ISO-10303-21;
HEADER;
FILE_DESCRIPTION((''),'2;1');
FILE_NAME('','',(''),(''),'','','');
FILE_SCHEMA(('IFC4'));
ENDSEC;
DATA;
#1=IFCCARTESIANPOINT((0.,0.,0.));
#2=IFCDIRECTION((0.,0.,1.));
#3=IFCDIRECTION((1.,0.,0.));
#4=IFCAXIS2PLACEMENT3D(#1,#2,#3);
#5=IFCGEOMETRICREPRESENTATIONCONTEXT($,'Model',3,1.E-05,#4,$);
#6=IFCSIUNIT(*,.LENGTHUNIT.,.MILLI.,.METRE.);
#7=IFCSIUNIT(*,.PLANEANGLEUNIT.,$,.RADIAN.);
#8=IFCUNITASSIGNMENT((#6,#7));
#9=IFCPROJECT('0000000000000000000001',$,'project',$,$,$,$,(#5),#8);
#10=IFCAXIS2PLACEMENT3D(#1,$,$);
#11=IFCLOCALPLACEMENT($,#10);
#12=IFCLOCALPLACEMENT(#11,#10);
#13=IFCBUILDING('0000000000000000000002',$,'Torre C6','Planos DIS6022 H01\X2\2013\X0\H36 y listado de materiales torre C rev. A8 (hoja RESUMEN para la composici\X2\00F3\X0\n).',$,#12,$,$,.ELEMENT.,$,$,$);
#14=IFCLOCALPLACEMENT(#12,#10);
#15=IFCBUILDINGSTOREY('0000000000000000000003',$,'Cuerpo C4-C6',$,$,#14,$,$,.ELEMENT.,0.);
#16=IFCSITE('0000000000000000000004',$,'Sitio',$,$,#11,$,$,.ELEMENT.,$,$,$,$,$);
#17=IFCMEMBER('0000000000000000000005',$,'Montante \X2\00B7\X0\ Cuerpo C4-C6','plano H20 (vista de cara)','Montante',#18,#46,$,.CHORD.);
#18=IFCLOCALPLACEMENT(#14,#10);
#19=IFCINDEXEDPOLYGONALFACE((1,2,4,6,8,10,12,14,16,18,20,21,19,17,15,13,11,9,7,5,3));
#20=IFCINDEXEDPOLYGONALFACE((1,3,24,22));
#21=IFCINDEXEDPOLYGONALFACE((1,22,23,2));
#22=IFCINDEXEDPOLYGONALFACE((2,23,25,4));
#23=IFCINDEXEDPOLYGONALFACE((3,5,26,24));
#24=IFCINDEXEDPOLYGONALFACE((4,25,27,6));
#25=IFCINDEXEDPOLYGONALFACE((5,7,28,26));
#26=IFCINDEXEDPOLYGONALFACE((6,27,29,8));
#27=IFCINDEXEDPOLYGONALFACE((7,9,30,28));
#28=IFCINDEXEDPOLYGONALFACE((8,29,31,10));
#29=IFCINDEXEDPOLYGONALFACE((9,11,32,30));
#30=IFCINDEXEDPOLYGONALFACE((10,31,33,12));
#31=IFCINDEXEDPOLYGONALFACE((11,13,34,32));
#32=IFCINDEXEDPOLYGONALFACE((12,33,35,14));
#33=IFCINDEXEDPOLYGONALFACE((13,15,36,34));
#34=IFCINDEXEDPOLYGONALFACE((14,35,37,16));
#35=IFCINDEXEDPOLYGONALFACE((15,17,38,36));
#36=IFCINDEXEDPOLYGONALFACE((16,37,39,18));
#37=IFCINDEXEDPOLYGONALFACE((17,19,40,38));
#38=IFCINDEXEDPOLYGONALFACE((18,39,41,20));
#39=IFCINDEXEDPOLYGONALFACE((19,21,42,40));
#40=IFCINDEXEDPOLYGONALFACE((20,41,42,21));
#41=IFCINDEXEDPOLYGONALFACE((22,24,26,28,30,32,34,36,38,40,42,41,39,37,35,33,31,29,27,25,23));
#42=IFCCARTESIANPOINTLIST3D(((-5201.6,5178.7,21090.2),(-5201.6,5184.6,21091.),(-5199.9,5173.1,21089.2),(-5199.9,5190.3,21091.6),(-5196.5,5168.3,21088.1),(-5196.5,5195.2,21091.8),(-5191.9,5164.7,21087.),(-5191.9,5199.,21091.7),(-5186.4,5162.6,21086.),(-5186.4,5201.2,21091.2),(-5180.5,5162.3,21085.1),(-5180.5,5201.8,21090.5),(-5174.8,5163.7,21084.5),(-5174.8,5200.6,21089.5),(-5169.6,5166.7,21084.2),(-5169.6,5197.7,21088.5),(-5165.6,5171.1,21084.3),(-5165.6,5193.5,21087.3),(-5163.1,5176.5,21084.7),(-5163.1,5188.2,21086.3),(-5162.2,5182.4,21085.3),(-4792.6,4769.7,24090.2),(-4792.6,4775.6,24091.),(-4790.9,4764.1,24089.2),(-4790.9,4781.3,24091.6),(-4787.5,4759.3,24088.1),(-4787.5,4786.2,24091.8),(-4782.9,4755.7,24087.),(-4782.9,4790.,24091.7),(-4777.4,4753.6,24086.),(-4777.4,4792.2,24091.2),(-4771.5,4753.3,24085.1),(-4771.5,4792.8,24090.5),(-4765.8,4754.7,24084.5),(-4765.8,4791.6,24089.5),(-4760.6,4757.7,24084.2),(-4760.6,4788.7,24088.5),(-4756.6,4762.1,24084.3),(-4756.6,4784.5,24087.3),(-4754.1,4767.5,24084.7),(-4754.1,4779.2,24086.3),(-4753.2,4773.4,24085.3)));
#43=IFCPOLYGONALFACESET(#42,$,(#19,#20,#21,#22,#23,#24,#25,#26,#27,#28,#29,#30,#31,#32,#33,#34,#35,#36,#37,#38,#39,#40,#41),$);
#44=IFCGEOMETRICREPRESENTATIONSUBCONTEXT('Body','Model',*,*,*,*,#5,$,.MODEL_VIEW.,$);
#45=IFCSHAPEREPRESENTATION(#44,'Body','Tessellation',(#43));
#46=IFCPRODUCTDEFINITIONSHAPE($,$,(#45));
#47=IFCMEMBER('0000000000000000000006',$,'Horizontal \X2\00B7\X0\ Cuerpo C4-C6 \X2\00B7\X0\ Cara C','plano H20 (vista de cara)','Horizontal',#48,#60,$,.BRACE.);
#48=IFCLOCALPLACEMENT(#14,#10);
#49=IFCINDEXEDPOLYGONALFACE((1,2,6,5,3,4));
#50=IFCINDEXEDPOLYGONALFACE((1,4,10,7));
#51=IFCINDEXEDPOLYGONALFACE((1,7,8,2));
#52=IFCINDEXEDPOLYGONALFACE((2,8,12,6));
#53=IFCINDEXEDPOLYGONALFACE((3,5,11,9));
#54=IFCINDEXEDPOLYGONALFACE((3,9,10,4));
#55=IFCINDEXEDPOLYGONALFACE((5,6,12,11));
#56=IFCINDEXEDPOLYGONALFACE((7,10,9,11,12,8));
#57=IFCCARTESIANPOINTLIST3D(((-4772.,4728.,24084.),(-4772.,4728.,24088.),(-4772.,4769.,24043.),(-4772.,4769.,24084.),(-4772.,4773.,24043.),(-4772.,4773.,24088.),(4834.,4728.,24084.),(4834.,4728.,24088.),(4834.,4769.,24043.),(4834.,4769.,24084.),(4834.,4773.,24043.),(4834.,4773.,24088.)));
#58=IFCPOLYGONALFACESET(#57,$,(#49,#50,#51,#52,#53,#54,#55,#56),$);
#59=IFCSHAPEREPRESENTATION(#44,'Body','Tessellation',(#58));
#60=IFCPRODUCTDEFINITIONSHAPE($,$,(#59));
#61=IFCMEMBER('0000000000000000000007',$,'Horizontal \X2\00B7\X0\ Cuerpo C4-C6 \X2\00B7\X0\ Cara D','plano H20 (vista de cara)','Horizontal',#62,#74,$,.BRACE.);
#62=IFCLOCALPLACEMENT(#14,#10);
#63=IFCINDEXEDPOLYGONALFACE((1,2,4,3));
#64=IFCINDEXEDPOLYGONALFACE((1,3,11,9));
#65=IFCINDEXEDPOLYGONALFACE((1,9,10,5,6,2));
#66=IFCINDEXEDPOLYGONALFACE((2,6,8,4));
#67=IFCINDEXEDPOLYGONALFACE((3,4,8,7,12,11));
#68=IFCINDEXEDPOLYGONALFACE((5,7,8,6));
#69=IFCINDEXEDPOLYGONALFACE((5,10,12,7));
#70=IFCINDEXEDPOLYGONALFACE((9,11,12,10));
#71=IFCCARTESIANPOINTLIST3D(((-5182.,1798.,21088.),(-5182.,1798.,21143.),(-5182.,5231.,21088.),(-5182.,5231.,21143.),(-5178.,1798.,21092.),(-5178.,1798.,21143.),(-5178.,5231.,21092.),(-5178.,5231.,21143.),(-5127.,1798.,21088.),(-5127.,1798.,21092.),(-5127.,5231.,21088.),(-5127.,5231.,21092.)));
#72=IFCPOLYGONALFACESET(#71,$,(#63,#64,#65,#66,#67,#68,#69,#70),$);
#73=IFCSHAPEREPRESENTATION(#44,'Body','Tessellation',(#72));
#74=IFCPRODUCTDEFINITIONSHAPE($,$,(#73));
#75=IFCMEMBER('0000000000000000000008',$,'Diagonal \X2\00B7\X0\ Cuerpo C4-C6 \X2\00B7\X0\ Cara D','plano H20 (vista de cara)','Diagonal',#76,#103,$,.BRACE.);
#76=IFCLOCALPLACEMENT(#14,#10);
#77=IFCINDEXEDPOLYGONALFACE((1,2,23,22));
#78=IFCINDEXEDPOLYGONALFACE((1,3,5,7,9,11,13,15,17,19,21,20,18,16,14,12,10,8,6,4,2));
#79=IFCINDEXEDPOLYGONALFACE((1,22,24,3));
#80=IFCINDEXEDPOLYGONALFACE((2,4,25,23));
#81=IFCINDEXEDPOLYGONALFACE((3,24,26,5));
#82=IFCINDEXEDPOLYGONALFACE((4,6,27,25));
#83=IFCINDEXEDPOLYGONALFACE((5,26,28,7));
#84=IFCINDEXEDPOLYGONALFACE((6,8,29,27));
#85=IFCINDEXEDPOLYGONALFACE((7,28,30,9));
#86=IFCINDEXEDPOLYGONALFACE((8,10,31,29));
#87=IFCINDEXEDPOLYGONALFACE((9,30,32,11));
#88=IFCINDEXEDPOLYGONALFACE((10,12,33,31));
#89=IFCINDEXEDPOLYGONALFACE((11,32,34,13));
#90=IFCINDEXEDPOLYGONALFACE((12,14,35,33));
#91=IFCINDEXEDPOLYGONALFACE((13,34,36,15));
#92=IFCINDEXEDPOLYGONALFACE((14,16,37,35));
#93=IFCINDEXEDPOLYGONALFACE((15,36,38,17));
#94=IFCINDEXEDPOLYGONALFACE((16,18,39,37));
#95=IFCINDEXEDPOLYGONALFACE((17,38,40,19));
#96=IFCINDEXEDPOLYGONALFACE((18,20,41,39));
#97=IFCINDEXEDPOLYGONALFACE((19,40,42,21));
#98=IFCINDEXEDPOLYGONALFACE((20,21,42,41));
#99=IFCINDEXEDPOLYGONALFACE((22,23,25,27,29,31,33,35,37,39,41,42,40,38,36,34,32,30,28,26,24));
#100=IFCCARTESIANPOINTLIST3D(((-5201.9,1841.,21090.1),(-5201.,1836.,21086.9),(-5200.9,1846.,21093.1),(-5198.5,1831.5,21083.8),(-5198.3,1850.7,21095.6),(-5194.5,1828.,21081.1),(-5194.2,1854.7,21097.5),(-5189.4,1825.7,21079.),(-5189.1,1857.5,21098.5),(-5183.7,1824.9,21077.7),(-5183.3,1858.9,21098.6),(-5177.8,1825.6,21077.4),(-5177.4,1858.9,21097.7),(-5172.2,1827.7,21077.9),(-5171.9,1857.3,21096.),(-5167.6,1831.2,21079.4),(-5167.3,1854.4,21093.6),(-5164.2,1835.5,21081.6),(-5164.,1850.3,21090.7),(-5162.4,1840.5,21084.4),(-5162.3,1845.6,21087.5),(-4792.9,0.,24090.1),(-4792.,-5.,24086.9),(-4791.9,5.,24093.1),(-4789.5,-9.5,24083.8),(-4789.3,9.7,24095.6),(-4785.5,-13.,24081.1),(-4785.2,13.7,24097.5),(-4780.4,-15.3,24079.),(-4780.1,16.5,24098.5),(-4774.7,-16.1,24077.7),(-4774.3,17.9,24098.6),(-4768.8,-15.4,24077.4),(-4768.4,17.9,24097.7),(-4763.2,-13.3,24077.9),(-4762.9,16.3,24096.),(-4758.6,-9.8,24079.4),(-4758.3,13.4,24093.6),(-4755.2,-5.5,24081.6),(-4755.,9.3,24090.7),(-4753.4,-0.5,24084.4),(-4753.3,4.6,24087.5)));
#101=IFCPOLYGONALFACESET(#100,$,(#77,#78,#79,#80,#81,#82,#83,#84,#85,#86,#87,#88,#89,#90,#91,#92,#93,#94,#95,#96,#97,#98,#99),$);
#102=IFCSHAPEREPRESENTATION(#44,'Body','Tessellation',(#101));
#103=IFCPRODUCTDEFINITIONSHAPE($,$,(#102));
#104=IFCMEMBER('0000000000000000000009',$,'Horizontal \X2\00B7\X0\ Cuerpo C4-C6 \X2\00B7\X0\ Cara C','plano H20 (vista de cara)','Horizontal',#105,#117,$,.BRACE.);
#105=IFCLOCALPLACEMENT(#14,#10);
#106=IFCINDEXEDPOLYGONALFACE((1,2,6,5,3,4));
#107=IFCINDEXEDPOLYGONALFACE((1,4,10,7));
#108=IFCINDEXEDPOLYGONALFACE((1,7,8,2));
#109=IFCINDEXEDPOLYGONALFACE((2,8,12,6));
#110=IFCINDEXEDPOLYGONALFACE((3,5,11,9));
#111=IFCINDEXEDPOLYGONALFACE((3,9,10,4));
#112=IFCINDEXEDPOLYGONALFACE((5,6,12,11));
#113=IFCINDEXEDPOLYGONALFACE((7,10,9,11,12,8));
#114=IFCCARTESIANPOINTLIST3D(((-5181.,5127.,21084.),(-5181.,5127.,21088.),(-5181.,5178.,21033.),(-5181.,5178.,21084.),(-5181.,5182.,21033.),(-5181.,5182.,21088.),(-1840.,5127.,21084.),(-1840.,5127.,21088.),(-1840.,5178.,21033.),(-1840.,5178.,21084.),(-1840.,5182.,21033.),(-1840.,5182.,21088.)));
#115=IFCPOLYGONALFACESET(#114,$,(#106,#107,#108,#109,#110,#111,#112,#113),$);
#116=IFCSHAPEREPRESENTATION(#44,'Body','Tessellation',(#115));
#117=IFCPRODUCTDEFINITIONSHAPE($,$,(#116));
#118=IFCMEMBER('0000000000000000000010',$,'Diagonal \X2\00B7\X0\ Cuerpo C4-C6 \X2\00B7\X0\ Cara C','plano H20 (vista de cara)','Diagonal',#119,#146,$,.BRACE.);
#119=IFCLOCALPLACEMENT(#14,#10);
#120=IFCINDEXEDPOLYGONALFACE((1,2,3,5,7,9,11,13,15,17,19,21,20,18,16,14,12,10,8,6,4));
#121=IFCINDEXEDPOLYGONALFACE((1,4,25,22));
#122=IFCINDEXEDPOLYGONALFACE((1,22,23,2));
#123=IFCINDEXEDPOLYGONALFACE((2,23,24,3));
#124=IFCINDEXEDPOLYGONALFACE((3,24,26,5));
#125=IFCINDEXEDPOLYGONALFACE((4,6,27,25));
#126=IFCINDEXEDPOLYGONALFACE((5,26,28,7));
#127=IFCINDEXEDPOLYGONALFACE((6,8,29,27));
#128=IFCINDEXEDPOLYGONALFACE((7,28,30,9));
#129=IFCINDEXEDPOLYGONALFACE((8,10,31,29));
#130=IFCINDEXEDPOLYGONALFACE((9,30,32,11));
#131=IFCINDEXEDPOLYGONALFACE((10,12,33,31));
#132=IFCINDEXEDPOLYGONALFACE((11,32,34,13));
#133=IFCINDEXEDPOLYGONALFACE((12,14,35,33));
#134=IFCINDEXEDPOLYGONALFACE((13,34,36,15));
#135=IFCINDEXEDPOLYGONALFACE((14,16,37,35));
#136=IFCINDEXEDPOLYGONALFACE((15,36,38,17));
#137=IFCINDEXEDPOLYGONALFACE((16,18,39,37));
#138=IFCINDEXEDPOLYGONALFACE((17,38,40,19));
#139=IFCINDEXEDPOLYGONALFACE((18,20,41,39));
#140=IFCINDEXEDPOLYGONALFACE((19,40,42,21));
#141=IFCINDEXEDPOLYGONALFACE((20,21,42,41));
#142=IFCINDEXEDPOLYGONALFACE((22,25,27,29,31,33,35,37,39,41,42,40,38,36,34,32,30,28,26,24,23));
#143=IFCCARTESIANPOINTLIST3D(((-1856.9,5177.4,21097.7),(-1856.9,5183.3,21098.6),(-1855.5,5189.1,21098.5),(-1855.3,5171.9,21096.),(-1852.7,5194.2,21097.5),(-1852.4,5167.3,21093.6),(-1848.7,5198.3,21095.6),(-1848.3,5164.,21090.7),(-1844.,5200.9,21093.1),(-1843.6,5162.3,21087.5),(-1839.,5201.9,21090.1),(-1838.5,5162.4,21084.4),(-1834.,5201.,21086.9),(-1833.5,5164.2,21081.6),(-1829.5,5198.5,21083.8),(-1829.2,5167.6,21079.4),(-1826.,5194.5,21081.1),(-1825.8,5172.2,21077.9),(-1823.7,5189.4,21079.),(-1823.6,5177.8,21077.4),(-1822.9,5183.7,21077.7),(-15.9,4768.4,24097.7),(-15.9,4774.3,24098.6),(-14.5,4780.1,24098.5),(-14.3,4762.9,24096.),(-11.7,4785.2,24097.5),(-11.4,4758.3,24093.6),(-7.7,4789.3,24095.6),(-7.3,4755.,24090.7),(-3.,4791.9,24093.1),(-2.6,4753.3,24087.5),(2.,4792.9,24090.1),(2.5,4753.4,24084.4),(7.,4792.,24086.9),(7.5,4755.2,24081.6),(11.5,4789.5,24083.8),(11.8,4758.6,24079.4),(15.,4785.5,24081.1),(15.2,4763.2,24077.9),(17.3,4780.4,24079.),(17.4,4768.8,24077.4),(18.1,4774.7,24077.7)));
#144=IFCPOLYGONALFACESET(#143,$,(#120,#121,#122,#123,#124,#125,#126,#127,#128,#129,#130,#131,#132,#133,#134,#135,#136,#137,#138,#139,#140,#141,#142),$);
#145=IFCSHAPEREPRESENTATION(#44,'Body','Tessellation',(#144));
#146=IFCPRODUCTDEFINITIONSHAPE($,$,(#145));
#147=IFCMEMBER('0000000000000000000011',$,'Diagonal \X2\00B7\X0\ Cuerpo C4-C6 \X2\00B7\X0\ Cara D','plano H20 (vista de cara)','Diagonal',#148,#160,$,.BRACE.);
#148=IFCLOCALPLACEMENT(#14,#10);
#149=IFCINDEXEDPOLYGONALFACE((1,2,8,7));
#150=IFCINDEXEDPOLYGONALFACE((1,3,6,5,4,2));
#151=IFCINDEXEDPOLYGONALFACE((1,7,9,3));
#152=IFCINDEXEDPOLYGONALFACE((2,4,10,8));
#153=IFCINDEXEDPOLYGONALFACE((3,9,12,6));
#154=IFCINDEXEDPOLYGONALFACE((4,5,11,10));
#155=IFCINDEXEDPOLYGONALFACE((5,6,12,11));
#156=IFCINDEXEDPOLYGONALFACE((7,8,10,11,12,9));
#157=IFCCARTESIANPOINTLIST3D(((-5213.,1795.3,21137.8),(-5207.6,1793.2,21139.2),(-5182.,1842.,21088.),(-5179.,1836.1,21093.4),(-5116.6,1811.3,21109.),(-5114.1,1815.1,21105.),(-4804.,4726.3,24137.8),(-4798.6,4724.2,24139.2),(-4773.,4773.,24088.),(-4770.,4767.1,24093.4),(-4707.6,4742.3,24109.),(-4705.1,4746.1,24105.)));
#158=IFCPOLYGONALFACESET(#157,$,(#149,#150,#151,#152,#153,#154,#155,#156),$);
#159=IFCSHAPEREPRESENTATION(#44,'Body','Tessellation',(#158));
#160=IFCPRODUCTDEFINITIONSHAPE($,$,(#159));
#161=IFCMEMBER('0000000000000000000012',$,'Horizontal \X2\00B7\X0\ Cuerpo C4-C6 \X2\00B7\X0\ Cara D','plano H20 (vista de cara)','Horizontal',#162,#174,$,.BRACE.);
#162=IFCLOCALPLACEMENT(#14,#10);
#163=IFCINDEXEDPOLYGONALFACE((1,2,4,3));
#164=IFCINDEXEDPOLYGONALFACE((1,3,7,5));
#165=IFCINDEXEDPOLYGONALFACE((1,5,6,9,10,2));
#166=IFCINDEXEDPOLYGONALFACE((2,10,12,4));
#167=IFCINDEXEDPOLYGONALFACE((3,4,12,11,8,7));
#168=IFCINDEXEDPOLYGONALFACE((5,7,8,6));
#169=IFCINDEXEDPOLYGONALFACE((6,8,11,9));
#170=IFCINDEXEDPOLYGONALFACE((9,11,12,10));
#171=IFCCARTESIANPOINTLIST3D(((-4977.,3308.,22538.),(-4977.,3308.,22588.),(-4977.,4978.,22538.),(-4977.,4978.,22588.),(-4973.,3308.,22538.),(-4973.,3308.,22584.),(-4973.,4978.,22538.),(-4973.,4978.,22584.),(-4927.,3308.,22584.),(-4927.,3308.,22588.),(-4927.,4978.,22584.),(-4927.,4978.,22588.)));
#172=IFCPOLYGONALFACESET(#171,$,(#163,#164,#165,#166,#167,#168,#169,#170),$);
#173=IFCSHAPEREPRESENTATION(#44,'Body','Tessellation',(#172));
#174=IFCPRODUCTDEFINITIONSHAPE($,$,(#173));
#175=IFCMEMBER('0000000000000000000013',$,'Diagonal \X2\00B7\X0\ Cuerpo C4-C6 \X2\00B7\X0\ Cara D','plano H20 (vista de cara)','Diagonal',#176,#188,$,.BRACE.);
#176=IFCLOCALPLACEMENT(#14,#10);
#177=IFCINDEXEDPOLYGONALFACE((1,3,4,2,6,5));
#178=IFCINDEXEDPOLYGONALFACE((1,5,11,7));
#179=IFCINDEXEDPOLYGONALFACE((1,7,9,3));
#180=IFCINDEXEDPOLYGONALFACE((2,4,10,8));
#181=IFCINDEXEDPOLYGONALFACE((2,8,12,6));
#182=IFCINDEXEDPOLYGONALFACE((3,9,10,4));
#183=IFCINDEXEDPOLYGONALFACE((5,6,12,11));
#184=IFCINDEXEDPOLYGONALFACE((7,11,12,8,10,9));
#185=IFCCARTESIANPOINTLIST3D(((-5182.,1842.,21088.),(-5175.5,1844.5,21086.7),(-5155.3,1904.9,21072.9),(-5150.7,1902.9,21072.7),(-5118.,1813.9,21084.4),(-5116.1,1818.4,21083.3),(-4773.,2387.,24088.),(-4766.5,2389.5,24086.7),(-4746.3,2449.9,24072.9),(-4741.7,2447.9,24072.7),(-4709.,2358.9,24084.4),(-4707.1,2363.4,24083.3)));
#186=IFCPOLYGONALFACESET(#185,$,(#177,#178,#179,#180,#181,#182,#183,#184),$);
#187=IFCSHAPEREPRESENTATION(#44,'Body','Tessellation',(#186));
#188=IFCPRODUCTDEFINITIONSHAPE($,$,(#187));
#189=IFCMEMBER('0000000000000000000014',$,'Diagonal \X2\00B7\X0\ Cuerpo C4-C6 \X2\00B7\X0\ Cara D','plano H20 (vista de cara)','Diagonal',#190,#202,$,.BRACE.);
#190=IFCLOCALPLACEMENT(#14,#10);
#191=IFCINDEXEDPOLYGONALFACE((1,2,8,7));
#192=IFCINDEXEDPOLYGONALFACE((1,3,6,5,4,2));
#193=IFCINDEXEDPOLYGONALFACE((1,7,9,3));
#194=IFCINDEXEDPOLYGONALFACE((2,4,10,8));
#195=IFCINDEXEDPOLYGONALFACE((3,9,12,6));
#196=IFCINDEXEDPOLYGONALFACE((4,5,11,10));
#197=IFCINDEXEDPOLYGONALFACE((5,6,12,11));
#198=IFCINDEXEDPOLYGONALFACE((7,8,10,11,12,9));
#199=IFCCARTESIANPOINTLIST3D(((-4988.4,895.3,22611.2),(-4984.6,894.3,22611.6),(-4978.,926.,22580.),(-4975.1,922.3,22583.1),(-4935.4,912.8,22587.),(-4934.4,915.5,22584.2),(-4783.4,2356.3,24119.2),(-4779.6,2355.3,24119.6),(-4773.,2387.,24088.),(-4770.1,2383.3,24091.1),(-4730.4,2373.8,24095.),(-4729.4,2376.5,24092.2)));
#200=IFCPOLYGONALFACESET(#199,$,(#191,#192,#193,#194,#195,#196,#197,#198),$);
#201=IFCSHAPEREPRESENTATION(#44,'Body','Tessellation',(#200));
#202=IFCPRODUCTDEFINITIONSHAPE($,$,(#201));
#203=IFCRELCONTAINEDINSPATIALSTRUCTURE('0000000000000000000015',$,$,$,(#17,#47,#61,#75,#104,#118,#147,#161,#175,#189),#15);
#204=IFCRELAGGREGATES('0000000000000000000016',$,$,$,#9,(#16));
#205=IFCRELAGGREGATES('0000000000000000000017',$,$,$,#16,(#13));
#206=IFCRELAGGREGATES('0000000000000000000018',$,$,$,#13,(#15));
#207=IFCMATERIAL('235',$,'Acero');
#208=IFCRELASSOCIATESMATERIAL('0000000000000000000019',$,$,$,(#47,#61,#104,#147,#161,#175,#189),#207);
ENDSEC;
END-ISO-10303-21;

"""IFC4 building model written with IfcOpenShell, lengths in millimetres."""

from ifc_helpers import new_model, si_unit, frame, frame_2d, origin, origin_with_axes, place, context, subcontext, project, spatial, circle, l_section, extrude, material, element, save


model = new_model("IFC4")

# Units and contexts
model_context = context("Model", 3, precision=1e-05, world=origin_with_axes())
body_context = subcontext(model_context, "Body", "Model", "MODEL_VIEW")
ifc_project = project(units=[si_unit("LENGTHUNIT", "METRE", prefix="MILLI"), si_unit("PLANEANGLEUNIT", "RADIAN")], contexts=[model_context])

# Site, building, storey
site_placement = place(None, origin())
site = spatial("IfcSite", under=ifc_project, at=site_placement, Name="Sitio", CompositionType="ELEMENT")
building_placement = place(site_placement, origin())
building = spatial("IfcBuilding", under=site, at=building_placement, Name="Torre C6", Description="Planos DIS6022 H01–H36 y listado de materiales torre C rev. A8 (hoja RESUMEN para la composición).", CompositionType="ELEMENT")
storey_placement = place(building_placement, origin())
storey = spatial("IfcBuildingStorey", under=building, at=storey_placement, Name="Cuerpo C4-C6", CompositionType="ELEMENT", Elevation=0.0)

# Members
member_1_placement = place(storey_placement, frame((-4773.0, 4773.0, 24088.0), z_axis=(-0.133868, 0.133868, -0.981916), x_axis=(0.990999, 0.018083, -0.132641)))
element("IfcMember", 1, at=member_1_placement, inside=storey, Name="Montante · Cuerpo C4-C6", Description="plano H20 (vista de cara)", ObjectType="Montante", PredefinedType="CHORD", context=body_context, shape_type="SweptSolid", body=[
    extrude(circle(Radius=20.0), None, (0.0, 0.0, 1.0), 3055.3),
])
ifc_material_1 = material(Name="235", Category="Acero")
member_2_placement = place(storey_placement, frame((-4772.0, 4773.0, 24088.0), z_axis=(1.0, 0.0, 0.0), x_axis=(0.0, -1.0, 0.0)))
element("IfcMember", 2, at=member_2_placement, inside=storey, material=ifc_material_1, Name="Horizontal · Cuerpo C4-C6 · Cara C", Description="plano H20 (vista de cara)", ObjectType="Horizontal", PredefinedType="BRACE", context=body_context, shape_type="SweptSolid", body=[
    extrude(l_section(Depth=45.0, Width=45.0, Thickness=4.0, at=frame_2d((22.5, 22.5))), None, (0.0, 0.0, 1.0), 9606.0),
])
member_3_placement = place(storey_placement, frame((-5182.0, 5231.0, 21088.0), z_axis=(0.0, -1.0, 0.0), x_axis=(1.0, 0.0, 0.0)))
element("IfcMember", 3, at=member_3_placement, inside=storey, material=ifc_material_1, Name="Horizontal · Cuerpo C4-C6 · Cara D", Description="plano H20 (vista de cara)", ObjectType="Horizontal", PredefinedType="BRACE", context=body_context, shape_type="SweptSolid", body=[
    extrude(l_section(Depth=55.0, Width=55.0, Thickness=4.0, at=frame_2d((27.5, 27.5))), None, (0.0, 0.0, 1.0), 3433.0),
])
member_4_placement = place(storey_placement, frame((-5182.0, 1842.0, 21088.0), z_axis=(0.115422, -0.519539, 0.846615), x_axis=(0.98074, -0.075594, -0.180097)))
element("IfcMember", 4, at=member_4_placement, inside=storey, Name="Diagonal · Cuerpo C4-C6 · Cara D", Description="plano H20 (vista de cara)", ObjectType="Diagonal", PredefinedType="BRACE", context=body_context, shape_type="SweptSolid", body=[
    extrude(circle(Radius=20.0), None, (0.0, 0.0, 1.0), 3543.5),
])
member_5_placement = place(storey_placement, frame((-5181.0, 5182.0, 21088.0), z_axis=(1.0, 0.0, 0.0), x_axis=(0.0, -1.0, 0.0)))
element("IfcMember", 5, at=member_5_placement, inside=storey, material=ifc_material_1, Name="Horizontal · Cuerpo C4-C6 · Cara C", Description="plano H20 (vista de cara)", ObjectType="Horizontal", PredefinedType="BRACE", context=body_context, shape_type="SweptSolid", body=[
    extrude(l_section(Depth=55.0, Width=55.0, Thickness=4.0, at=frame_2d((27.5, 27.5))), None, (0.0, 0.0, 1.0), 3341.0),
])
member_6_placement = place(storey_placement, frame((-1840.0, 5182.0, 21088.0), z_axis=(0.519539, -0.115422, 0.846615), x_axis=(0.075301, -0.980794, -0.179925)))
element("IfcMember", 6, at=member_6_placement, inside=storey, Name="Diagonal · Cuerpo C4-C6 · Cara C", Description="plano H20 (vista de cara)", ObjectType="Diagonal", PredefinedType="BRACE", context=body_context, shape_type="SweptSolid", body=[
    extrude(circle(Radius=20.0), None, (0.0, 0.0, 1.0), 3543.5),
])
member_7_placement = place(storey_placement, frame((-4773.0, 4773.0, 24088.0), z_axis=(-0.097057, -0.695534, -0.711908), x_axis=(0.905276, -0.35893, 0.227256)))
element("IfcMember", 7, at=member_7_placement, inside=storey, material=ifc_material_1, Name="Diagonal · Cuerpo C4-C6 · Cara D", Description="plano H20 (vista de cara)", ObjectType="Diagonal", PredefinedType="BRACE", context=body_context, shape_type="SweptSolid", body=[
    extrude(l_section(Depth=75.0, Width=75.0, Thickness=6.0, at=frame_2d((37.5, 37.5))), None, (0.0, 0.0, 1.0), 4214.0),
])
member_8_placement = place(storey_placement, frame((-4977.0, 3308.0, 22588.0), z_axis=(0.0, 1.0, 0.0), x_axis=(1.0, 0.0, 0.0)))
element("IfcMember", 8, at=member_8_placement, inside=storey, material=ifc_material_1, Name="Horizontal · Cuerpo C4-C6 · Cara D", Description="plano H20 (vista de cara)", ObjectType="Horizontal", PredefinedType="BRACE", context=body_context, shape_type="SweptSolid", body=[
    extrude(l_section(Depth=50.0, Width=50.0, Thickness=4.0, at=frame_2d((25.0, 25.0))), None, (0.0, 0.0, 1.0), 1670.0),
])
member_9_placement = place(storey_placement, frame((-5182.0, 1842.0, 21088.0), z_axis=(0.132947, 0.177154, 0.975162), x_axis=(0.914624, -0.400966, -0.051852)))
element("IfcMember", 9, at=member_9_placement, inside=storey, material=ifc_material_1, Name="Diagonal · Cuerpo C4-C6 · Cara D", Description="plano H20 (vista de cara)", ObjectType="Diagonal", PredefinedType="BRACE", context=body_context, shape_type="SweptSolid", body=[
    extrude(l_section(Depth=70.0, Width=70.0, Thickness=5.0, at=frame_2d((35.0, 35.0))), None, (0.0, 0.0, 1.0), 3076.4),
])
member_10_placement = place(storey_placement, frame((-4773.0, 2387.0, 24088.0), z_axis=(-0.097173, -0.692533, -0.714812), x_axis=(0.967863, -0.233132, 0.094293)))
element("IfcMember", 10, at=member_10_placement, inside=storey, material=ifc_material_1, Name="Diagonal · Cuerpo C4-C6 · Cara D", Description="plano H20 (vista de cara)", ObjectType="Diagonal", PredefinedType="BRACE", context=body_context, shape_type="SweptSolid", body=[
    extrude(l_section(Depth=45.0, Width=45.0, Thickness=4.0, at=frame_2d((22.5, 22.5))), None, (0.0, 0.0, 1.0), 2109.6),
])

save(model, "model.ifc")
